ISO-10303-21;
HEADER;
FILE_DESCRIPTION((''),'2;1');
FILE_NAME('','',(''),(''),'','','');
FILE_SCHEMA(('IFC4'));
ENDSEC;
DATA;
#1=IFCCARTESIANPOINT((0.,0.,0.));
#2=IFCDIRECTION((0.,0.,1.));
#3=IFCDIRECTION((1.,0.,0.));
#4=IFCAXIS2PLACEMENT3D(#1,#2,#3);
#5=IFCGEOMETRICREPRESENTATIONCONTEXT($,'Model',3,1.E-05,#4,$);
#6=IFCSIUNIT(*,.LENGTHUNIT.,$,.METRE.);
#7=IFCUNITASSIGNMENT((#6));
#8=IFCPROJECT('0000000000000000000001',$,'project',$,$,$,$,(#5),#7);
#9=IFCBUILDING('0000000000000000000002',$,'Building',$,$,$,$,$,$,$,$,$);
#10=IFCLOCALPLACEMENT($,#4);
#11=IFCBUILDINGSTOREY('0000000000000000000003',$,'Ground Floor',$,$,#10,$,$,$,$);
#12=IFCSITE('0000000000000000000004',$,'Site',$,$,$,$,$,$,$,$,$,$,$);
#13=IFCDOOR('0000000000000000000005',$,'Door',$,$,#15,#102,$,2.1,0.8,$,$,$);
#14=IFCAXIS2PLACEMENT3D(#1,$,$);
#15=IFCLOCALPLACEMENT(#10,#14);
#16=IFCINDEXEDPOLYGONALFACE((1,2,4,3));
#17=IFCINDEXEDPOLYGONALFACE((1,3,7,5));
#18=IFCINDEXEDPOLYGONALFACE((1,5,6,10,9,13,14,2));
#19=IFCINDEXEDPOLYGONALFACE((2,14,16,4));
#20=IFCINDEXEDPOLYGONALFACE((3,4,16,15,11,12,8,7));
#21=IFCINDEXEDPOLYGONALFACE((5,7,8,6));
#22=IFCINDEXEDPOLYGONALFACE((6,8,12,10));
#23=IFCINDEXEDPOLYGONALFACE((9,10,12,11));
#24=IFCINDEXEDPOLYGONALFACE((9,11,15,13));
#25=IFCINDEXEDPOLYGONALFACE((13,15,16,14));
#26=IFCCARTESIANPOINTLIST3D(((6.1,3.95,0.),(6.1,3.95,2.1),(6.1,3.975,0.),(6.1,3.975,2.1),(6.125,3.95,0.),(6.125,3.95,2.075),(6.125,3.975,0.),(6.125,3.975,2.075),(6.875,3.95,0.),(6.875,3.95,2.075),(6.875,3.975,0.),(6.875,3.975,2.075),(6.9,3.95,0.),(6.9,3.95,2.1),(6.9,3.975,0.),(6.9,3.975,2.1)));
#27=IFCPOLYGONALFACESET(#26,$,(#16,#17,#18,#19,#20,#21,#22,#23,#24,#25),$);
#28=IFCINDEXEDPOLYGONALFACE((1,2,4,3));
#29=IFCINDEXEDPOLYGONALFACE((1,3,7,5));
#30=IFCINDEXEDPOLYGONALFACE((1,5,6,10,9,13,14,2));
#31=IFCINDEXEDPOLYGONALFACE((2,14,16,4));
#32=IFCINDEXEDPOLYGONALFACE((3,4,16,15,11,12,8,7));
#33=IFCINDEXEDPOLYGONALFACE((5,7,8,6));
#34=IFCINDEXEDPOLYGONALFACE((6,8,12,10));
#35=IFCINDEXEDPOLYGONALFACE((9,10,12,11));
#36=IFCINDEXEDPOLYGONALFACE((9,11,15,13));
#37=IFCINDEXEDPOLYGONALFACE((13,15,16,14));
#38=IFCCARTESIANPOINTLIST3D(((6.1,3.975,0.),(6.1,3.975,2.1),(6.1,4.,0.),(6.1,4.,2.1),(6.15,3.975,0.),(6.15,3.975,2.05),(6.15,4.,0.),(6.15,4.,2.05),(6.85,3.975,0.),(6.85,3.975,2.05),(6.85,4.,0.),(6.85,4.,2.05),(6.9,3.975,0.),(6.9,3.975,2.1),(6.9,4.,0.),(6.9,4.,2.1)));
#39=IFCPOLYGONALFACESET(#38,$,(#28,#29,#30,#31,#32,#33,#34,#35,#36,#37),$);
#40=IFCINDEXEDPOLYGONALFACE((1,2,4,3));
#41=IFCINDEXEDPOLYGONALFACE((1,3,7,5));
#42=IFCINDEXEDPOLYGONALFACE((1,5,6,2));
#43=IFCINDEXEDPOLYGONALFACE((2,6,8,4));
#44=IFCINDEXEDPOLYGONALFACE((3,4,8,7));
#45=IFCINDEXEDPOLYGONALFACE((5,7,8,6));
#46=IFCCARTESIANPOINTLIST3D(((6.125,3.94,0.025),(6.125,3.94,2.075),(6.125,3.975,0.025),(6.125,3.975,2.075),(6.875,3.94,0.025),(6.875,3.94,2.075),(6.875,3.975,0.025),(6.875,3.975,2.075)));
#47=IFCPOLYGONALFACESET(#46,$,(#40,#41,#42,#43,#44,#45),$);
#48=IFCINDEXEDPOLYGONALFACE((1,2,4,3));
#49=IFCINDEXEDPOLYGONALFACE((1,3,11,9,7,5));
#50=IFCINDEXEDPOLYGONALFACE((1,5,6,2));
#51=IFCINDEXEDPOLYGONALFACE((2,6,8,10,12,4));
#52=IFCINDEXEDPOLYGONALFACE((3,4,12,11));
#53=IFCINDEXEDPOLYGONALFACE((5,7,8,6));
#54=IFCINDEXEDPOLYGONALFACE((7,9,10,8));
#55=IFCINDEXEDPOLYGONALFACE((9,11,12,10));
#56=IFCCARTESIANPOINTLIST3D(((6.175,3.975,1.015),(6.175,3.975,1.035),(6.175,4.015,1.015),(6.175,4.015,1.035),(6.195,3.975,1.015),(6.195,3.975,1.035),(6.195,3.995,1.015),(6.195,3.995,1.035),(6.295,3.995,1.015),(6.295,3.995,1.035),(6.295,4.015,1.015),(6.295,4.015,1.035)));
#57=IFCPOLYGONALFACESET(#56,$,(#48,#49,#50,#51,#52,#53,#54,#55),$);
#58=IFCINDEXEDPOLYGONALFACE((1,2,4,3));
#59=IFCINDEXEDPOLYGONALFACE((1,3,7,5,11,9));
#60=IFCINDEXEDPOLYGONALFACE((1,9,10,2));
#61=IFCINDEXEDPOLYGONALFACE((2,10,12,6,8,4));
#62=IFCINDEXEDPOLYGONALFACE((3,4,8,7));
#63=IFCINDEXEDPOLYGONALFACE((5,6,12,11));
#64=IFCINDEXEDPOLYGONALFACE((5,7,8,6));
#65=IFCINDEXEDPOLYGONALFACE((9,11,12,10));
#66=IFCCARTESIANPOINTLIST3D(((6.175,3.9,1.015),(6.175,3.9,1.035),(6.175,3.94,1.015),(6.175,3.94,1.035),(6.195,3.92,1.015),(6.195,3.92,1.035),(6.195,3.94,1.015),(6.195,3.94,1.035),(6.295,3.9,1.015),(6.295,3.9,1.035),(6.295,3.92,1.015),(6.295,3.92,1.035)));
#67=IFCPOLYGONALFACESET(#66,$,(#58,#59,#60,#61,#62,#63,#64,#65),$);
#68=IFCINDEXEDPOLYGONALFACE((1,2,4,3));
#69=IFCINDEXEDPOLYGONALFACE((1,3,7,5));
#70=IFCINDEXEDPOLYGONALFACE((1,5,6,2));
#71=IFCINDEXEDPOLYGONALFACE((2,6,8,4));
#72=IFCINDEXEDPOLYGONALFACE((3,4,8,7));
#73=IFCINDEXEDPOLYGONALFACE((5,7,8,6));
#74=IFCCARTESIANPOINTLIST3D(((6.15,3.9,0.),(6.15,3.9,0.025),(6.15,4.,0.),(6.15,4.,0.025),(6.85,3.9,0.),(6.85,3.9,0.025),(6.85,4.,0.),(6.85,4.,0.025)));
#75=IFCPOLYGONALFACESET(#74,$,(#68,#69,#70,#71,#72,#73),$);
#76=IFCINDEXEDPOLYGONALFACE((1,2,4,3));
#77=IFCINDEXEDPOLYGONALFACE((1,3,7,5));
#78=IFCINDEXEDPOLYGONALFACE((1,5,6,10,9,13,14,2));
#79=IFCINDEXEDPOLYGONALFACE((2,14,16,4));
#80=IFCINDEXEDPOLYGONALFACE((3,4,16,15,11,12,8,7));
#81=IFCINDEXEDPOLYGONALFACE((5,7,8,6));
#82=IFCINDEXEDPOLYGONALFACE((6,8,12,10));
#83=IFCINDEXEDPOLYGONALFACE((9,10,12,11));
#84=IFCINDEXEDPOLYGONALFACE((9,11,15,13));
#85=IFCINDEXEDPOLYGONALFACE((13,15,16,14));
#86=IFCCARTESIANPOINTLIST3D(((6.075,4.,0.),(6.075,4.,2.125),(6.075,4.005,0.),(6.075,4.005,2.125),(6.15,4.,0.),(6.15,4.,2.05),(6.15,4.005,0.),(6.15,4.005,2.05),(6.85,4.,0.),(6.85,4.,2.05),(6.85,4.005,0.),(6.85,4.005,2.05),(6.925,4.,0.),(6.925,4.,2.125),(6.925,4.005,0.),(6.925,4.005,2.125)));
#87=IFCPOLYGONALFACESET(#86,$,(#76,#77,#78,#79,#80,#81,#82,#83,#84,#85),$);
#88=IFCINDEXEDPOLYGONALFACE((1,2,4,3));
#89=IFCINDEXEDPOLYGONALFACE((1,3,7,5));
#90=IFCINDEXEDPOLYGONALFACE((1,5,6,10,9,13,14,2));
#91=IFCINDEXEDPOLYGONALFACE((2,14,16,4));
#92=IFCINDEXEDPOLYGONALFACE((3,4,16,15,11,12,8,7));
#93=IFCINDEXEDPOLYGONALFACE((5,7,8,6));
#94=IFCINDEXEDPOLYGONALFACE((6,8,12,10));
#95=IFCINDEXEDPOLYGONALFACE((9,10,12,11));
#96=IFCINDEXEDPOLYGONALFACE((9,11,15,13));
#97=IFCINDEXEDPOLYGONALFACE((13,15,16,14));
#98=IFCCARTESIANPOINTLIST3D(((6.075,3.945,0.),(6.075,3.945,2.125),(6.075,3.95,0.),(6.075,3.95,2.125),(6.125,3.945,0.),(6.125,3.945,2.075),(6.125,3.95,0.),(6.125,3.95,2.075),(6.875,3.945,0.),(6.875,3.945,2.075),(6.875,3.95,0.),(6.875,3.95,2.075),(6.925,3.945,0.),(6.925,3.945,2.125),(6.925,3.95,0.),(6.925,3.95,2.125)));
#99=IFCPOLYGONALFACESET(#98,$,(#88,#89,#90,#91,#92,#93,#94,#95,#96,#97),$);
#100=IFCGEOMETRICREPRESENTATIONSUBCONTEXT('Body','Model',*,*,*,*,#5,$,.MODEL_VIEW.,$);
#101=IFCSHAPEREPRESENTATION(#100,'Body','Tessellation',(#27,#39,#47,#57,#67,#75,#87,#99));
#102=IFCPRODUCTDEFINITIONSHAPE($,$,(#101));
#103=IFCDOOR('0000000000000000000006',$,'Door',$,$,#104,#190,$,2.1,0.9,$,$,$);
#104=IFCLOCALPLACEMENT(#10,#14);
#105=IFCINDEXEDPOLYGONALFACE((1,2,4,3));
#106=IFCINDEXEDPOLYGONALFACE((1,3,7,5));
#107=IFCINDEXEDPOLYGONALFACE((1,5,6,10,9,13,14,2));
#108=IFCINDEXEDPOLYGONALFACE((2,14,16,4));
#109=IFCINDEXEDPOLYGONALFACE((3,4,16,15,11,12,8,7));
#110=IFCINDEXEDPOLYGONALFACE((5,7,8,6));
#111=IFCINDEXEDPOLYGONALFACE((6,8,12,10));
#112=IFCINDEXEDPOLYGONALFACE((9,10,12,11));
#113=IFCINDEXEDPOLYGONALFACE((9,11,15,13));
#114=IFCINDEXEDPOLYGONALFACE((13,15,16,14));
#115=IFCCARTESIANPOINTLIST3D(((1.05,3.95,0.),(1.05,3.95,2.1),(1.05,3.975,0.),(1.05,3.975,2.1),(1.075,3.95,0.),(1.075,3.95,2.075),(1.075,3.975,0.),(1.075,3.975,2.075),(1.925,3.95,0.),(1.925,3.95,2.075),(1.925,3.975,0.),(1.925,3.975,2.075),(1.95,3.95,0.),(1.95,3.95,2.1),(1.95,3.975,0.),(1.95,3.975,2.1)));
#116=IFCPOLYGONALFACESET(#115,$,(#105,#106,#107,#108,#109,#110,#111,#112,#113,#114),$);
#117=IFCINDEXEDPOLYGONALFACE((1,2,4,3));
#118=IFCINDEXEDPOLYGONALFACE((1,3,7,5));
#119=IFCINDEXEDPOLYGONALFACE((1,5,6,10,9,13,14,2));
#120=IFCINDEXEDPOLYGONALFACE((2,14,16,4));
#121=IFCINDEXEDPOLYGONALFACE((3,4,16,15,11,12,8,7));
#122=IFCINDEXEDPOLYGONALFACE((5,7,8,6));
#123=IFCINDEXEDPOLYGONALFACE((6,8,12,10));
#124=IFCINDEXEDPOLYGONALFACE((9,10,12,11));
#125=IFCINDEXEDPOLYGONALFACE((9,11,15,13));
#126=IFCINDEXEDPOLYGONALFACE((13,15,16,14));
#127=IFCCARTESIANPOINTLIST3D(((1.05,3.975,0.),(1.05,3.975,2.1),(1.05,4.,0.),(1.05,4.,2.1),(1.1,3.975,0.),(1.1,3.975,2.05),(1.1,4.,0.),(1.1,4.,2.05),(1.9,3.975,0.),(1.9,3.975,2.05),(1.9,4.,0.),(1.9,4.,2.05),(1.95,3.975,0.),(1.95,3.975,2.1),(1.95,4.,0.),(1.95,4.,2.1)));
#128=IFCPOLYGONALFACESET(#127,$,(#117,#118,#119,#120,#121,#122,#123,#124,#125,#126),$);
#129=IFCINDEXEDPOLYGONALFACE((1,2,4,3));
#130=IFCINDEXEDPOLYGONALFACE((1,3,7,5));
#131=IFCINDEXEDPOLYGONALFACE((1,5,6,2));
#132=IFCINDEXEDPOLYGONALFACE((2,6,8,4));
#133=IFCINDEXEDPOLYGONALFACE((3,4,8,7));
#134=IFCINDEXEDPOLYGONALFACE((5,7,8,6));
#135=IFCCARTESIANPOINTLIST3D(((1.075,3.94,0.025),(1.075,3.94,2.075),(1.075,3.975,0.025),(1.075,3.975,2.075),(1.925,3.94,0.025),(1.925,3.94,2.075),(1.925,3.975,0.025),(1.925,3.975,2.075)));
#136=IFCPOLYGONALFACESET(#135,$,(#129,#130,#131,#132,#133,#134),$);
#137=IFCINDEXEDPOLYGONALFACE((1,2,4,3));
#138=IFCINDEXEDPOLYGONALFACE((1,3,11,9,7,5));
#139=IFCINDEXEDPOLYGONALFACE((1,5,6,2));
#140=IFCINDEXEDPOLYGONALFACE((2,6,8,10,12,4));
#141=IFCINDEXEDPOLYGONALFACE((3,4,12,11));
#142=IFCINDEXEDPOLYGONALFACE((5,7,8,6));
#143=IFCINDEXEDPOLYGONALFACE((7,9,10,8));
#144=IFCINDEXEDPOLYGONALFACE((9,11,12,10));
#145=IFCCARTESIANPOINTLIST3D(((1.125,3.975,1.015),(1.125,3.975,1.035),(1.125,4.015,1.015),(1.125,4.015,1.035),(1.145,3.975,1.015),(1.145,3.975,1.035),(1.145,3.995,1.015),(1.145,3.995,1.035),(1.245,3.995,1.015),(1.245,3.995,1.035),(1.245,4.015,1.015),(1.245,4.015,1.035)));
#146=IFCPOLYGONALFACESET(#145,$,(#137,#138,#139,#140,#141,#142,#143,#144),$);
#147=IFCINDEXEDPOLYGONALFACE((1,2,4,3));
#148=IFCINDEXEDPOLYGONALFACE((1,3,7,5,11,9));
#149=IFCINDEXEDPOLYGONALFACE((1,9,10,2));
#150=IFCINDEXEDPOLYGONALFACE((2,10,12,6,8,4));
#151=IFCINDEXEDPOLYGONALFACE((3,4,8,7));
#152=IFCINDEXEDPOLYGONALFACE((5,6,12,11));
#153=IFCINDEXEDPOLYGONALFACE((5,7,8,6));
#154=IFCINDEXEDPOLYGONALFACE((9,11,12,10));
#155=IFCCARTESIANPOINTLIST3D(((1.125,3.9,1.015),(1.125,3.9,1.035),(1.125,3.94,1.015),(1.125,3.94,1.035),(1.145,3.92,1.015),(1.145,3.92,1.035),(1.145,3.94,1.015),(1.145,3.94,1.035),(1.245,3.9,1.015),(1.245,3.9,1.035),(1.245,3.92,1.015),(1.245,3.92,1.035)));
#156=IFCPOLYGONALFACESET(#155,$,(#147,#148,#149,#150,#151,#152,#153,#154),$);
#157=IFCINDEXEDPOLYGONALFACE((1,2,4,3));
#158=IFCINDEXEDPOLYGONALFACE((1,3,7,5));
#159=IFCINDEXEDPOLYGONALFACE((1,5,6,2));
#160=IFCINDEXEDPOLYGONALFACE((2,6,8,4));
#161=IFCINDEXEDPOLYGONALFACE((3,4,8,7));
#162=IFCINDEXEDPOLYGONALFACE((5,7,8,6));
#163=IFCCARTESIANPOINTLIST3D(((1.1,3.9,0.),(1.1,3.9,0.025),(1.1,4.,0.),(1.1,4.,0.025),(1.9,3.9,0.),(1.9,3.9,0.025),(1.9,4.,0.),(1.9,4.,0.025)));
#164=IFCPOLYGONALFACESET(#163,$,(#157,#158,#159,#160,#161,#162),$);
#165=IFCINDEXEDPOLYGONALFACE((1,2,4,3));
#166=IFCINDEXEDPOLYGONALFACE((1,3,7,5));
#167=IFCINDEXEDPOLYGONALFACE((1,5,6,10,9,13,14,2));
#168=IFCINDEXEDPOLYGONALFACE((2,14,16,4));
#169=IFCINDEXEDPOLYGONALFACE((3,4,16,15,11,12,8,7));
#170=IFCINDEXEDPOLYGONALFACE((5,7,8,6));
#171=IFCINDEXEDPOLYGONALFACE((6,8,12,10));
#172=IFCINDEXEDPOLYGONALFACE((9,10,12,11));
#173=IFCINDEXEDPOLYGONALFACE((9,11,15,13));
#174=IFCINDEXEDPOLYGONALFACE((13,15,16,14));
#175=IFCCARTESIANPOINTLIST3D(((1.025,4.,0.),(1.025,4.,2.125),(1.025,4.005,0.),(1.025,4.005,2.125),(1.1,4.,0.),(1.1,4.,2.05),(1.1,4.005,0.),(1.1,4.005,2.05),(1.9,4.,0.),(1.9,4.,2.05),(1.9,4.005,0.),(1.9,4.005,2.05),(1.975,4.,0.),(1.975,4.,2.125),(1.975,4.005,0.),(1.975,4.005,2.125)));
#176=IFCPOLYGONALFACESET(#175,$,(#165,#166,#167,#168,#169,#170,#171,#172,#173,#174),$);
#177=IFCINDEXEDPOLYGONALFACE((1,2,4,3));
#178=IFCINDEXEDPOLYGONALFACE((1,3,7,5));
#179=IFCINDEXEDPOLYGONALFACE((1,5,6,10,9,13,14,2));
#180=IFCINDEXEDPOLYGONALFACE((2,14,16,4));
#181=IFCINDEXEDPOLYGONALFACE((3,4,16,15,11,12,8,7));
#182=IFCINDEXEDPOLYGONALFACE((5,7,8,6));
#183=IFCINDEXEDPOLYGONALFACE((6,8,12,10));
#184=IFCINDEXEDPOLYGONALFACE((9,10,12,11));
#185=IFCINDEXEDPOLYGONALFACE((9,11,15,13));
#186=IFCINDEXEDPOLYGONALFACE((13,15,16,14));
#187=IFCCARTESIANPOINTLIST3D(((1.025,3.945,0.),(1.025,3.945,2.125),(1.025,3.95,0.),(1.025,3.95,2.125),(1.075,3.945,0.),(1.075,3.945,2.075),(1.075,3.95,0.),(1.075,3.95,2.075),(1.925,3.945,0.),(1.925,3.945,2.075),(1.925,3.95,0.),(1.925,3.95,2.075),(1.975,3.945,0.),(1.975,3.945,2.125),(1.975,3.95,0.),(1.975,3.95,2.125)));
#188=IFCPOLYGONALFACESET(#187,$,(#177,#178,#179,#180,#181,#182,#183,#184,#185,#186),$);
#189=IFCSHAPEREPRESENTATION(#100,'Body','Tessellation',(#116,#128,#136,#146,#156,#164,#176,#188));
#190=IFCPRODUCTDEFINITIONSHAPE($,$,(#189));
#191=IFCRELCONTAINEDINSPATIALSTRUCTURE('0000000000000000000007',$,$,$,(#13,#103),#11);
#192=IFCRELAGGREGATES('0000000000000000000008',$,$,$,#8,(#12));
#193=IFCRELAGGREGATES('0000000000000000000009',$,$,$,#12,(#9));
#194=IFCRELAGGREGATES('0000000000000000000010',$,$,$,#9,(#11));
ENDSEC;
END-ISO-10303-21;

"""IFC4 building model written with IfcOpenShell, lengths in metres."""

from ifc_helpers import new_model, si_unit, frame, origin_with_axes, place, context, subcontext, project, spatial, line, indexed_curve, outline, extrude, element, save


model = new_model("IFC4")

# Units and contexts
model_context = context("Model", 3, precision=1e-05, world=origin_with_axes())
body_context = subcontext(model_context, "Body", "Model", "MODEL_VIEW")
ifc_project = project(units=[si_unit("LENGTHUNIT", "METRE")], contexts=[model_context])

# Site, building, storey
site = spatial("IfcSite", under=ifc_project, Name="Site")
building = spatial("IfcBuilding", under=site, Name="Building")
storey_placement = place(None, origin_with_axes())
storey = spatial("IfcBuildingStorey", under=building, at=storey_placement, Name="Ground Floor")

# Doors
door_1_placement = place(storey_placement, frame((6.9, 4.0, 0.0), z_axis=(0.0, 0.0, 1.0), x_axis=(-1.0, 0.0, 0.0)))
element("IfcDoor", 1, at=door_1_placement, inside=storey, Name="Door", OverallHeight=2.1, OverallWidth=0.8, context=body_context, shape_type="SweptSolid", body=[
    extrude(outline(indexed_curve([(0.0, 0.0), (0.0, 2.1), (0.8, 2.1), (0.8, 0.0), (0.775, 0.0), (0.775, 2.075), (0.025, 2.075), (0.025, 0.0)], segments=[line(1, 2, 3, 4, 5, 6, 7, 8, 1)])), frame((0.0, 0.025, 0.0), z_axis=(0.0, -1.0, 0.0), x_axis=(1.0, 0.0, 0.0)), (0.0, 0.0, -1.0), 0.025),
    extrude(outline(indexed_curve([(0.0, 0.0), (0.0, 2.1), (0.8, 2.1), (0.8, 0.0), (0.75, 0.0), (0.75, 2.05), (0.05, 2.05), (0.05, 0.0)], segments=[line(1, 2, 3, 4, 5, 6, 7, 8, 1)])), frame((0.0, 0.0, 0.0), z_axis=(0.0, -1.0, 0.0), x_axis=(1.0, 0.0, 0.0)), (0.0, 0.0, -1.0), 0.025),
    extrude(outline(indexed_curve([(0.0, 0.0), (0.75, 0.0), (0.75, 0.035), (0.0, 0.035)], segments=[line(1, 2, 3, 4, 1)])), frame((0.025, 0.025, 0.025), z_axis=(0.0, 0.0, 1.0), x_axis=(1.0, 0.0, 0.0)), (0.0, 0.0, 1.0), 2.05),
    extrude(outline(indexed_curve([(0.0, 0.0), (0.0, -0.04), (-0.12, -0.04), (-0.12, -0.02), (-0.02, -0.02), (-0.02, 0.0)], segments=[line(1, 2, 3, 4, 5, 6, 1)])), frame((0.725, 0.025, 1.015), z_axis=(0.0, 0.0, 1.0), x_axis=(1.0, 0.0, 0.0)), (0.0, 0.0, 1.0), 0.02),
    extrude(outline(indexed_curve([(0.0, 0.0), (0.0, 0.04), (-0.12, 0.04), (-0.12, 0.02), (-0.02, 0.02), (-0.02, 0.0)], segments=[line(1, 2, 3, 4, 5, 6, 1)])), frame((0.725, 0.06, 1.015), z_axis=(0.0, 0.0, 1.0), x_axis=(1.0, 0.0, 0.0)), (0.0, 0.0, 1.0), 0.02),
    extrude(outline(indexed_curve([(0.0, 0.0), (0.7, 0.0), (0.7, 0.1), (0.0, 0.1)], segments=[line(1, 2, 3, 4, 1)])), frame((0.05, 0.0, 0.0), z_axis=(0.0, 0.0, 1.0), x_axis=(1.0, 0.0, 0.0)), (0.0, 0.0, 1.0), 0.025),
    extrude(outline(indexed_curve([(0.0, 0.0), (0.0, 2.125), (0.85, 2.125), (0.85, 0.0), (0.775, 0.0), (0.775, 2.05), (0.075, 2.05), (0.075, 0.0)], segments=[line(1, 2, 3, 4, 5, 6, 7, 8, 1)])), frame((-0.025, -0.005, 0.0), z_axis=(0.0, -1.0, 0.0), x_axis=(1.0, 0.0, 0.0)), (0.0, 0.0, -1.0), 0.005),
    extrude(outline(indexed_curve([(0.0, 0.0), (0.0, 2.125), (0.85, 2.125), (0.85, 0.0), (0.8, 0.0), (0.8, 2.075), (0.05, 2.075), (0.05, 0.0)], segments=[line(1, 2, 3, 4, 5, 6, 7, 8, 1)])), frame((-0.025, 0.05, 0.0), z_axis=(0.0, -1.0, 0.0), x_axis=(1.0, 0.0, 0.0)), (0.0, 0.0, -1.0), 0.005),
])
door_2_placement = place(storey_placement, frame((1.95, 4.0, 0.0), z_axis=(0.0, 0.0, 1.0), x_axis=(-1.0, 0.0, 0.0)))
element("IfcDoor", 2, at=door_2_placement, inside=storey, Name="Door", OverallHeight=2.1, OverallWidth=0.9, context=body_context, shape_type="SweptSolid", body=[
    extrude(outline(indexed_curve([(0.0, 0.0), (0.0, 2.1), (0.9, 2.1), (0.9, 0.0), (0.875, 0.0), (0.875, 2.075), (0.025, 2.075), (0.025, 0.0)], segments=[line(1, 2, 3, 4, 5, 6, 7, 8, 1)])), frame((0.0, 0.025, 0.0), z_axis=(0.0, -1.0, 0.0), x_axis=(1.0, 0.0, 0.0)), (0.0, 0.0, -1.0), 0.025),
    extrude(outline(indexed_curve([(0.0, 0.0), (0.0, 2.1), (0.9, 2.1), (0.9, 0.0), (0.85, 0.0), (0.85, 2.05), (0.05, 2.05), (0.05, 0.0)], segments=[line(1, 2, 3, 4, 5, 6, 7, 8, 1)])), frame((0.0, 0.0, 0.0), z_axis=(0.0, -1.0, 0.0), x_axis=(1.0, 0.0, 0.0)), (0.0, 0.0, -1.0), 0.025),
    extrude(outline(indexed_curve([(0.0, 0.0), (0.85, 0.0), (0.85, 0.035), (0.0, 0.035)], segments=[line(1, 2, 3, 4, 1)])), frame((0.025, 0.025, 0.025), z_axis=(0.0, 0.0, 1.0), x_axis=(1.0, 0.0, 0.0)), (0.0, 0.0, 1.0), 2.05),
    extrude(outline(indexed_curve([(0.0, 0.0), (0.0, -0.04), (-0.12, -0.04), (-0.12, -0.02), (-0.02, -0.02), (-0.02, 0.0)], segments=[line(1, 2, 3, 4, 5, 6, 1)])), frame((0.825, 0.025, 1.015), z_axis=(0.0, 0.0, 1.0), x_axis=(1.0, 0.0, 0.0)), (0.0, 0.0, 1.0), 0.02),
    extrude(outline(indexed_curve([(0.0, 0.0), (0.0, 0.04), (-0.12, 0.04), (-0.12, 0.02), (-0.02, 0.02), (-0.02, 0.0)], segments=[line(1, 2, 3, 4, 5, 6, 1)])), frame((0.825, 0.06, 1.015), z_axis=(0.0, 0.0, 1.0), x_axis=(1.0, 0.0, 0.0)), (0.0, 0.0, 1.0), 0.02),
    extrude(outline(indexed_curve([(0.0, 0.0), (0.8, 0.0), (0.8, 0.1), (0.0, 0.1)], segments=[line(1, 2, 3, 4, 1)])), frame((0.05, 0.0, 0.0), z_axis=(0.0, 0.0, 1.0), x_axis=(1.0, 0.0, 0.0)), (0.0, 0.0, 1.0), 0.025),
    extrude(outline(indexed_curve([(0.0, 0.0), (0.0, 2.125), (0.95, 2.125), (0.95, 0.0), (0.875, 0.0), (0.875, 2.05), (0.075, 2.05), (0.075, 0.0)], segments=[line(1, 2, 3, 4, 5, 6, 7, 8, 1)])), frame((-0.025, -0.005, 0.0), z_axis=(0.0, -1.0, 0.0), x_axis=(1.0, 0.0, 0.0)), (0.0, 0.0, -1.0), 0.005),
    extrude(outline(indexed_curve([(0.0, 0.0), (0.0, 2.125), (0.95, 2.125), (0.95, 0.0), (0.9, 0.0), (0.9, 2.075), (0.05, 2.075), (0.05, 0.0)], segments=[line(1, 2, 3, 4, 5, 6, 7, 8, 1)])), frame((-0.025, 0.05, 0.0), z_axis=(0.0, -1.0, 0.0), x_axis=(1.0, 0.0, 0.0)), (0.0, 0.0, -1.0), 0.005),
])

save(model, "model.ifc")
